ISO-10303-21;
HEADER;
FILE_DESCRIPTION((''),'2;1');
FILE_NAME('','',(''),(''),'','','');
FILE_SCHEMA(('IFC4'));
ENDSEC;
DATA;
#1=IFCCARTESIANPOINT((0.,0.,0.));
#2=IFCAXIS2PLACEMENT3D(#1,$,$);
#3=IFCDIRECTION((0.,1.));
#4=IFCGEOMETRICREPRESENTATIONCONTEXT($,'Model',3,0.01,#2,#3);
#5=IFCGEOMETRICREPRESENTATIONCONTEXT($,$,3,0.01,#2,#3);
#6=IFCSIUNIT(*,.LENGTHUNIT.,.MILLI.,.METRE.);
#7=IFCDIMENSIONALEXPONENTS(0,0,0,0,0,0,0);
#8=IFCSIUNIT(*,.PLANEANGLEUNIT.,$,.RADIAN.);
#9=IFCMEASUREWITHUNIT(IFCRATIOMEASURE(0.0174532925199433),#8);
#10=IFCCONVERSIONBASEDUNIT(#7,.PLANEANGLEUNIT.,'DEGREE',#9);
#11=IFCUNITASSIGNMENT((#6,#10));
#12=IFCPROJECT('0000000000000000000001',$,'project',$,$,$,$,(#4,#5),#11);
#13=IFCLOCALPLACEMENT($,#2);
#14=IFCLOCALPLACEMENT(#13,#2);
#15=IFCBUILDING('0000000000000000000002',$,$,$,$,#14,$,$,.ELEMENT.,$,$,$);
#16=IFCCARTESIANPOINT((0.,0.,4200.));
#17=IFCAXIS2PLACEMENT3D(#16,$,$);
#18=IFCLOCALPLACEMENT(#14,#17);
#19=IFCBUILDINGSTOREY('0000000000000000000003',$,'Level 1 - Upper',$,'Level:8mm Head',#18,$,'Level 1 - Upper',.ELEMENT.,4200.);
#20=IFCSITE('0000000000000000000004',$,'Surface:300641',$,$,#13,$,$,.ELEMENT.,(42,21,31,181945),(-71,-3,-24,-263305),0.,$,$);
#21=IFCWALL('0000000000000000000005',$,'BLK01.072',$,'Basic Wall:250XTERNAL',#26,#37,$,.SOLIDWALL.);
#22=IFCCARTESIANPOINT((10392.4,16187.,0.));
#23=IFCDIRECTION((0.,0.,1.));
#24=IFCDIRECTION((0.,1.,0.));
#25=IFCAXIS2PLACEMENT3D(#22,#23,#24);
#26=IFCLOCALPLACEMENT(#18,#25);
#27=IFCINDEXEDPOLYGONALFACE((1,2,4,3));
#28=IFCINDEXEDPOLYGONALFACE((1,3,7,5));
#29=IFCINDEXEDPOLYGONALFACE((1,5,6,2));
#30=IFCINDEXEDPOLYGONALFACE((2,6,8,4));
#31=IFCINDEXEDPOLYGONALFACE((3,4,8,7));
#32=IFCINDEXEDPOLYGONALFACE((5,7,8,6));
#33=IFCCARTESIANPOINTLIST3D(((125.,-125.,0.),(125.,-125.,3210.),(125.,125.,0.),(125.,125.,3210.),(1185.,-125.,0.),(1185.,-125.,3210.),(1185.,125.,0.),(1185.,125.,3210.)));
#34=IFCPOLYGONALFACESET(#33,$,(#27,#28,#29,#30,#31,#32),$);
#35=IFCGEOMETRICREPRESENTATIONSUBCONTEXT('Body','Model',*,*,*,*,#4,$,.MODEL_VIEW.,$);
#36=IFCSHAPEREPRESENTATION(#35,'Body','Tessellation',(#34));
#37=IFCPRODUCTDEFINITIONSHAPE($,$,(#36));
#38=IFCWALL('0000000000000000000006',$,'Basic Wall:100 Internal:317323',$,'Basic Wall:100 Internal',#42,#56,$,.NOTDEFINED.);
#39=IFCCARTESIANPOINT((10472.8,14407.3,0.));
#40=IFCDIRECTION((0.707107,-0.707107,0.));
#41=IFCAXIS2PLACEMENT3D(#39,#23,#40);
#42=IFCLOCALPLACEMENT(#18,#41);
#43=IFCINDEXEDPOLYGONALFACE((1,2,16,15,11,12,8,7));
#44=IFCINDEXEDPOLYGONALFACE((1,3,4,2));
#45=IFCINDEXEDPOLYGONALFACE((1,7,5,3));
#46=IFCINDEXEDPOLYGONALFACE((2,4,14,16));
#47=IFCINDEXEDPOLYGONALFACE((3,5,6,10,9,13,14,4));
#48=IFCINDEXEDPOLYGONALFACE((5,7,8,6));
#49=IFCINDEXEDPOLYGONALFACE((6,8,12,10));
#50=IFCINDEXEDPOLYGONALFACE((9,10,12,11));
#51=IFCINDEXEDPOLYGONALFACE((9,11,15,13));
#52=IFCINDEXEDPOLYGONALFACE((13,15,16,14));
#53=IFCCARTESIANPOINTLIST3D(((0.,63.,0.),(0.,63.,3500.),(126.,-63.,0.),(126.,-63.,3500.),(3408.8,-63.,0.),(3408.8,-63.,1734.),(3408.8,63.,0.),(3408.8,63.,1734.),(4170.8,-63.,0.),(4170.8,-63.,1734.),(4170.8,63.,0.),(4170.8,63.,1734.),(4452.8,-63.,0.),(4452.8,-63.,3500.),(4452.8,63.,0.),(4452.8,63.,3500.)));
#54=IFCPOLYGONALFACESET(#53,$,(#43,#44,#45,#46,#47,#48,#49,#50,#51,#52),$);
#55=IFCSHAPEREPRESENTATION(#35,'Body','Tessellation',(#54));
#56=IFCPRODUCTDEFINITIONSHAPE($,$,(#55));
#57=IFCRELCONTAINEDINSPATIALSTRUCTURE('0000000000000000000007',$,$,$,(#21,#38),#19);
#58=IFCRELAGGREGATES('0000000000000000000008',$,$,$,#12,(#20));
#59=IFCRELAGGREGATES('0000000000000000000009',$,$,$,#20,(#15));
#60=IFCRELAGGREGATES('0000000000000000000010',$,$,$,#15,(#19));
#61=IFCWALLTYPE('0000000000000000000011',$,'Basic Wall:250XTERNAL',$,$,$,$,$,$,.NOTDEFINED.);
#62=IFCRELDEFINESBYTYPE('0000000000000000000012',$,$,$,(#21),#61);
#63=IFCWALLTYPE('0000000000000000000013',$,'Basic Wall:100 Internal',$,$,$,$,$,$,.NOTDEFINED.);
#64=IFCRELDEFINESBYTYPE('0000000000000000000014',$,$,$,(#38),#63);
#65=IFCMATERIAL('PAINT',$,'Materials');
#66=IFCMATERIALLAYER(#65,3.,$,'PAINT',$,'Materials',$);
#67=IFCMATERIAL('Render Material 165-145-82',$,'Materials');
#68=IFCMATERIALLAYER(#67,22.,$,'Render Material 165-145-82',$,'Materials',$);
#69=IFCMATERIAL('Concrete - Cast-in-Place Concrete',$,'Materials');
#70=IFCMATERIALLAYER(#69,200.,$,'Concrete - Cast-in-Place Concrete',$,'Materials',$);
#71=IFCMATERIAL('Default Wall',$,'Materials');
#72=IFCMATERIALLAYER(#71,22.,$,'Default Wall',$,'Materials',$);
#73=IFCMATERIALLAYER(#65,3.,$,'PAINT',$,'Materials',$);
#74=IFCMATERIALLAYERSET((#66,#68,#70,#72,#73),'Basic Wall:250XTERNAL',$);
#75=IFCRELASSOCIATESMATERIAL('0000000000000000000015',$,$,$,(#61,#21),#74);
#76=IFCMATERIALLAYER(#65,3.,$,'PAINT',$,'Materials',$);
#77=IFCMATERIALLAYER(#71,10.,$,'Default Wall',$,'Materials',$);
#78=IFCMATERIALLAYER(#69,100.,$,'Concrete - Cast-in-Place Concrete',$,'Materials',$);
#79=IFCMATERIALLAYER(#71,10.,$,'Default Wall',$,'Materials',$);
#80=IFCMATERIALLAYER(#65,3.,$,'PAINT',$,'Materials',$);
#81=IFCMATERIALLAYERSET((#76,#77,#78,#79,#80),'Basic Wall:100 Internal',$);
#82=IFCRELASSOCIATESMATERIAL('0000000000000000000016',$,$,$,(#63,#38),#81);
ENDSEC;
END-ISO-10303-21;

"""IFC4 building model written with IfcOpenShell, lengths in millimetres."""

from ifc_helpers import new_model, entity, si_unit, converted_unit, direction, frame, frame_2d, origin, place, context, subcontext, project, spatial, polyline, rectangle, outline, extrude, clip, halfspace, bounded_halfspace, material, layer, layer_set, layer_usage, type_object, element, save


model = new_model("IFC4")

# Units and contexts
model_context = context("Model", 3, precision=0.01, world=origin(), true_north=direction((0.0, 1.0)))
context_of_model = context(None, 3, precision=0.01, world=origin(), true_north=direction((0.0, 1.0)))
body_context = subcontext(model_context, "Body", "Model", "MODEL_VIEW")
ifc_project = project(units=[si_unit("LENGTHUNIT", "METRE", prefix="MILLI"), converted_unit("PLANEANGLEUNIT", "DEGREE", entity("IfcRatioMeasure", 0.0174532925199433), si_unit("PLANEANGLEUNIT", "RADIAN"), dimensions=[0, 0, 0, 0, 0, 0, 0])], contexts=[model_context, context_of_model])

# Site, building, storey
site_placement = place(None, origin())
site = spatial("IfcSite", under=ifc_project, at=site_placement, Name="Surface:300641", CompositionType="ELEMENT", RefLatitude=(42, 21, 31, 181945), RefLongitude=(-71, -3, -24, -263305), RefElevation=0.0)
building_placement = place(site_placement, origin())
building = spatial("IfcBuilding", under=site, at=building_placement, CompositionType="ELEMENT")
storey_placement = place(building_placement, frame((0.0, 0.0, 4200.0)))
storey = spatial("IfcBuildingStorey", under=building, at=storey_placement, Name="Level 1 - Upper", ObjectType="Level:8mm Head", LongName="Level 1 - Upper", CompositionType="ELEMENT", Elevation=4200.0)

# Wall
ifc_material_1 = material(Name="PAINT", Category="Materials")
ifc_layer_1 = layer(ifc_material_1, 3.0, Name="PAINT", Category="Materials")
ifc_material_2 = material(Name="Render Material 165-145-82", Category="Materials")
ifc_layer_2 = layer(ifc_material_2, 22.0, Name="Render Material 165-145-82", Category="Materials")
ifc_material_3 = material(Name="Concrete - Cast-in-Place Concrete", Category="Materials")
ifc_layer_3 = layer(ifc_material_3, 200.0, Name="Concrete - Cast-in-Place Concrete", Category="Materials")
ifc_material_4 = material(Name="Default Wall", Category="Materials")
ifc_layer_4 = layer(ifc_material_4, 22.0, Name="Default Wall", Category="Materials")
ifc_layer_5 = layer(ifc_material_1, 3.0, Name="PAINT", Category="Materials")
ifc_layer_set_1 = layer_set([ifc_layer_1, ifc_layer_2, ifc_layer_3, ifc_layer_4, ifc_layer_5], Name="Basic Wall:250XTERNAL")
ifc_layer_usage_1 = layer_usage(ifc_layer_set_1, "AXIS2", "NEGATIVE", 125.0)
wall_type_1 = type_object("IfcWallType", Name="Basic Wall:250XTERNAL", PredefinedType="NOTDEFINED", material=ifc_layer_set_1)
wall_1_placement = place(storey_placement, frame((10392.4, 16187.0, 0.0), z_axis=(0.0, 0.0, 1.0), x_axis=(0.0, 1.0, 0.0)))
element("IfcWall", 1, at=wall_1_placement, inside=storey, type_object=wall_type_1, material=ifc_layer_usage_1, Name="BLK01.072", ObjectType="Basic Wall:250XTERNAL", PredefinedType="SOLIDWALL", context=body_context, shape_type="Clipping", body=[
    clip(clip(extrude(rectangle(XDim=1060.0, YDim=250.0, at=frame_2d((655.0, 0.0), x_axis=(-1.0, 0.0))), origin(), (0.0, 0.0, 1.0), 3210.0), bounded_halfspace(frame((0.0, -125.0, 3210.0), z_axis=(0.0, 0.0, -1.0), x_axis=(-1.0, 0.0, 0.0)), True, frame((0.0, -125.0, 3210.0)), polyline([(0.0, 0.0), (935.0, 0.0), (1185.0, 0.0), (1185.0, 250.0), (0.0, 250.0), (0.0, 0.0)]))), halfspace(frame((0.0, 0.0, -400.0)), True)),
])

# Shared definitions
ifc_layer_6 = layer(ifc_material_1, 3.0, Name="PAINT", Category="Materials")
ifc_layer_7 = layer(ifc_material_4, 10.0, Name="Default Wall", Category="Materials")
ifc_layer_8 = layer(ifc_material_3, 100.0, Name="Concrete - Cast-in-Place Concrete", Category="Materials")
ifc_layer_9 = layer(ifc_material_4, 10.0, Name="Default Wall", Category="Materials")
ifc_layer_10 = layer(ifc_material_1, 3.0, Name="PAINT", Category="Materials")
ifc_layer_set_2 = layer_set([ifc_layer_6, ifc_layer_7, ifc_layer_8, ifc_layer_9, ifc_layer_10], Name="Basic Wall:100 Internal")
wall_type_2 = type_object("IfcWallType", Name="Basic Wall:100 Internal", PredefinedType="NOTDEFINED", material=ifc_layer_set_2)

# Wall, opening
ifc_layer_usage_2 = layer_usage(ifc_layer_set_2, "AXIS2", "NEGATIVE", 63.0)
wall_2_placement = place(storey_placement, frame((10472.8, 14407.3, 0.0), z_axis=(0.0, 0.0, 1.0), x_axis=(0.707107, -0.707107, 0.0)))
wall_2 = element("IfcWall", 2, at=wall_2_placement, inside=storey, type_object=wall_type_2, material=ifc_layer_usage_2, Name="Basic Wall:100 Internal:317323", ObjectType="Basic Wall:100 Internal", PredefinedType="NOTDEFINED", context=body_context, shape_type="Clipping", body=[
    clip(extrude(outline(polyline([(126.0, -63.0), (1424.8, -63.0), (1674.8, -63.0), (4326.8, -63.0), (4452.8, -63.0), (4452.8, 63.0), (0.0, 63.0), (126.0, -63.0)])), origin(), (0.0, 0.0, 1.0), 3500.0), halfspace(origin(), True)),
])
opening_1_placement = place(wall_2_placement, frame((3789.8, -1968.0, -400.0), z_axis=(0.0, 0.0, 1.0), x_axis=(0.707107, 0.707107, 0.0)))
element("IfcOpeningElement", 3, at=opening_1_placement, cuts=wall_2, ObjectType="Opening", PredefinedType="OPENING", context=body_context, shape_type="SweptSolid", body=[
    extrude(rectangle(XDim=2134.0, YDim=762.0, at=frame_2d((0.0, 0.0), x_axis=(1.0, 0.0))), frame((269.4, 269.4, 1067.0), z_axis=(0.707107, 0.707107, 0.0), x_axis=(0.0, 0.0, 1.0)), (0.0, 0.0, 1.0), 3048.0),
])

save(model, "model.ifc")
